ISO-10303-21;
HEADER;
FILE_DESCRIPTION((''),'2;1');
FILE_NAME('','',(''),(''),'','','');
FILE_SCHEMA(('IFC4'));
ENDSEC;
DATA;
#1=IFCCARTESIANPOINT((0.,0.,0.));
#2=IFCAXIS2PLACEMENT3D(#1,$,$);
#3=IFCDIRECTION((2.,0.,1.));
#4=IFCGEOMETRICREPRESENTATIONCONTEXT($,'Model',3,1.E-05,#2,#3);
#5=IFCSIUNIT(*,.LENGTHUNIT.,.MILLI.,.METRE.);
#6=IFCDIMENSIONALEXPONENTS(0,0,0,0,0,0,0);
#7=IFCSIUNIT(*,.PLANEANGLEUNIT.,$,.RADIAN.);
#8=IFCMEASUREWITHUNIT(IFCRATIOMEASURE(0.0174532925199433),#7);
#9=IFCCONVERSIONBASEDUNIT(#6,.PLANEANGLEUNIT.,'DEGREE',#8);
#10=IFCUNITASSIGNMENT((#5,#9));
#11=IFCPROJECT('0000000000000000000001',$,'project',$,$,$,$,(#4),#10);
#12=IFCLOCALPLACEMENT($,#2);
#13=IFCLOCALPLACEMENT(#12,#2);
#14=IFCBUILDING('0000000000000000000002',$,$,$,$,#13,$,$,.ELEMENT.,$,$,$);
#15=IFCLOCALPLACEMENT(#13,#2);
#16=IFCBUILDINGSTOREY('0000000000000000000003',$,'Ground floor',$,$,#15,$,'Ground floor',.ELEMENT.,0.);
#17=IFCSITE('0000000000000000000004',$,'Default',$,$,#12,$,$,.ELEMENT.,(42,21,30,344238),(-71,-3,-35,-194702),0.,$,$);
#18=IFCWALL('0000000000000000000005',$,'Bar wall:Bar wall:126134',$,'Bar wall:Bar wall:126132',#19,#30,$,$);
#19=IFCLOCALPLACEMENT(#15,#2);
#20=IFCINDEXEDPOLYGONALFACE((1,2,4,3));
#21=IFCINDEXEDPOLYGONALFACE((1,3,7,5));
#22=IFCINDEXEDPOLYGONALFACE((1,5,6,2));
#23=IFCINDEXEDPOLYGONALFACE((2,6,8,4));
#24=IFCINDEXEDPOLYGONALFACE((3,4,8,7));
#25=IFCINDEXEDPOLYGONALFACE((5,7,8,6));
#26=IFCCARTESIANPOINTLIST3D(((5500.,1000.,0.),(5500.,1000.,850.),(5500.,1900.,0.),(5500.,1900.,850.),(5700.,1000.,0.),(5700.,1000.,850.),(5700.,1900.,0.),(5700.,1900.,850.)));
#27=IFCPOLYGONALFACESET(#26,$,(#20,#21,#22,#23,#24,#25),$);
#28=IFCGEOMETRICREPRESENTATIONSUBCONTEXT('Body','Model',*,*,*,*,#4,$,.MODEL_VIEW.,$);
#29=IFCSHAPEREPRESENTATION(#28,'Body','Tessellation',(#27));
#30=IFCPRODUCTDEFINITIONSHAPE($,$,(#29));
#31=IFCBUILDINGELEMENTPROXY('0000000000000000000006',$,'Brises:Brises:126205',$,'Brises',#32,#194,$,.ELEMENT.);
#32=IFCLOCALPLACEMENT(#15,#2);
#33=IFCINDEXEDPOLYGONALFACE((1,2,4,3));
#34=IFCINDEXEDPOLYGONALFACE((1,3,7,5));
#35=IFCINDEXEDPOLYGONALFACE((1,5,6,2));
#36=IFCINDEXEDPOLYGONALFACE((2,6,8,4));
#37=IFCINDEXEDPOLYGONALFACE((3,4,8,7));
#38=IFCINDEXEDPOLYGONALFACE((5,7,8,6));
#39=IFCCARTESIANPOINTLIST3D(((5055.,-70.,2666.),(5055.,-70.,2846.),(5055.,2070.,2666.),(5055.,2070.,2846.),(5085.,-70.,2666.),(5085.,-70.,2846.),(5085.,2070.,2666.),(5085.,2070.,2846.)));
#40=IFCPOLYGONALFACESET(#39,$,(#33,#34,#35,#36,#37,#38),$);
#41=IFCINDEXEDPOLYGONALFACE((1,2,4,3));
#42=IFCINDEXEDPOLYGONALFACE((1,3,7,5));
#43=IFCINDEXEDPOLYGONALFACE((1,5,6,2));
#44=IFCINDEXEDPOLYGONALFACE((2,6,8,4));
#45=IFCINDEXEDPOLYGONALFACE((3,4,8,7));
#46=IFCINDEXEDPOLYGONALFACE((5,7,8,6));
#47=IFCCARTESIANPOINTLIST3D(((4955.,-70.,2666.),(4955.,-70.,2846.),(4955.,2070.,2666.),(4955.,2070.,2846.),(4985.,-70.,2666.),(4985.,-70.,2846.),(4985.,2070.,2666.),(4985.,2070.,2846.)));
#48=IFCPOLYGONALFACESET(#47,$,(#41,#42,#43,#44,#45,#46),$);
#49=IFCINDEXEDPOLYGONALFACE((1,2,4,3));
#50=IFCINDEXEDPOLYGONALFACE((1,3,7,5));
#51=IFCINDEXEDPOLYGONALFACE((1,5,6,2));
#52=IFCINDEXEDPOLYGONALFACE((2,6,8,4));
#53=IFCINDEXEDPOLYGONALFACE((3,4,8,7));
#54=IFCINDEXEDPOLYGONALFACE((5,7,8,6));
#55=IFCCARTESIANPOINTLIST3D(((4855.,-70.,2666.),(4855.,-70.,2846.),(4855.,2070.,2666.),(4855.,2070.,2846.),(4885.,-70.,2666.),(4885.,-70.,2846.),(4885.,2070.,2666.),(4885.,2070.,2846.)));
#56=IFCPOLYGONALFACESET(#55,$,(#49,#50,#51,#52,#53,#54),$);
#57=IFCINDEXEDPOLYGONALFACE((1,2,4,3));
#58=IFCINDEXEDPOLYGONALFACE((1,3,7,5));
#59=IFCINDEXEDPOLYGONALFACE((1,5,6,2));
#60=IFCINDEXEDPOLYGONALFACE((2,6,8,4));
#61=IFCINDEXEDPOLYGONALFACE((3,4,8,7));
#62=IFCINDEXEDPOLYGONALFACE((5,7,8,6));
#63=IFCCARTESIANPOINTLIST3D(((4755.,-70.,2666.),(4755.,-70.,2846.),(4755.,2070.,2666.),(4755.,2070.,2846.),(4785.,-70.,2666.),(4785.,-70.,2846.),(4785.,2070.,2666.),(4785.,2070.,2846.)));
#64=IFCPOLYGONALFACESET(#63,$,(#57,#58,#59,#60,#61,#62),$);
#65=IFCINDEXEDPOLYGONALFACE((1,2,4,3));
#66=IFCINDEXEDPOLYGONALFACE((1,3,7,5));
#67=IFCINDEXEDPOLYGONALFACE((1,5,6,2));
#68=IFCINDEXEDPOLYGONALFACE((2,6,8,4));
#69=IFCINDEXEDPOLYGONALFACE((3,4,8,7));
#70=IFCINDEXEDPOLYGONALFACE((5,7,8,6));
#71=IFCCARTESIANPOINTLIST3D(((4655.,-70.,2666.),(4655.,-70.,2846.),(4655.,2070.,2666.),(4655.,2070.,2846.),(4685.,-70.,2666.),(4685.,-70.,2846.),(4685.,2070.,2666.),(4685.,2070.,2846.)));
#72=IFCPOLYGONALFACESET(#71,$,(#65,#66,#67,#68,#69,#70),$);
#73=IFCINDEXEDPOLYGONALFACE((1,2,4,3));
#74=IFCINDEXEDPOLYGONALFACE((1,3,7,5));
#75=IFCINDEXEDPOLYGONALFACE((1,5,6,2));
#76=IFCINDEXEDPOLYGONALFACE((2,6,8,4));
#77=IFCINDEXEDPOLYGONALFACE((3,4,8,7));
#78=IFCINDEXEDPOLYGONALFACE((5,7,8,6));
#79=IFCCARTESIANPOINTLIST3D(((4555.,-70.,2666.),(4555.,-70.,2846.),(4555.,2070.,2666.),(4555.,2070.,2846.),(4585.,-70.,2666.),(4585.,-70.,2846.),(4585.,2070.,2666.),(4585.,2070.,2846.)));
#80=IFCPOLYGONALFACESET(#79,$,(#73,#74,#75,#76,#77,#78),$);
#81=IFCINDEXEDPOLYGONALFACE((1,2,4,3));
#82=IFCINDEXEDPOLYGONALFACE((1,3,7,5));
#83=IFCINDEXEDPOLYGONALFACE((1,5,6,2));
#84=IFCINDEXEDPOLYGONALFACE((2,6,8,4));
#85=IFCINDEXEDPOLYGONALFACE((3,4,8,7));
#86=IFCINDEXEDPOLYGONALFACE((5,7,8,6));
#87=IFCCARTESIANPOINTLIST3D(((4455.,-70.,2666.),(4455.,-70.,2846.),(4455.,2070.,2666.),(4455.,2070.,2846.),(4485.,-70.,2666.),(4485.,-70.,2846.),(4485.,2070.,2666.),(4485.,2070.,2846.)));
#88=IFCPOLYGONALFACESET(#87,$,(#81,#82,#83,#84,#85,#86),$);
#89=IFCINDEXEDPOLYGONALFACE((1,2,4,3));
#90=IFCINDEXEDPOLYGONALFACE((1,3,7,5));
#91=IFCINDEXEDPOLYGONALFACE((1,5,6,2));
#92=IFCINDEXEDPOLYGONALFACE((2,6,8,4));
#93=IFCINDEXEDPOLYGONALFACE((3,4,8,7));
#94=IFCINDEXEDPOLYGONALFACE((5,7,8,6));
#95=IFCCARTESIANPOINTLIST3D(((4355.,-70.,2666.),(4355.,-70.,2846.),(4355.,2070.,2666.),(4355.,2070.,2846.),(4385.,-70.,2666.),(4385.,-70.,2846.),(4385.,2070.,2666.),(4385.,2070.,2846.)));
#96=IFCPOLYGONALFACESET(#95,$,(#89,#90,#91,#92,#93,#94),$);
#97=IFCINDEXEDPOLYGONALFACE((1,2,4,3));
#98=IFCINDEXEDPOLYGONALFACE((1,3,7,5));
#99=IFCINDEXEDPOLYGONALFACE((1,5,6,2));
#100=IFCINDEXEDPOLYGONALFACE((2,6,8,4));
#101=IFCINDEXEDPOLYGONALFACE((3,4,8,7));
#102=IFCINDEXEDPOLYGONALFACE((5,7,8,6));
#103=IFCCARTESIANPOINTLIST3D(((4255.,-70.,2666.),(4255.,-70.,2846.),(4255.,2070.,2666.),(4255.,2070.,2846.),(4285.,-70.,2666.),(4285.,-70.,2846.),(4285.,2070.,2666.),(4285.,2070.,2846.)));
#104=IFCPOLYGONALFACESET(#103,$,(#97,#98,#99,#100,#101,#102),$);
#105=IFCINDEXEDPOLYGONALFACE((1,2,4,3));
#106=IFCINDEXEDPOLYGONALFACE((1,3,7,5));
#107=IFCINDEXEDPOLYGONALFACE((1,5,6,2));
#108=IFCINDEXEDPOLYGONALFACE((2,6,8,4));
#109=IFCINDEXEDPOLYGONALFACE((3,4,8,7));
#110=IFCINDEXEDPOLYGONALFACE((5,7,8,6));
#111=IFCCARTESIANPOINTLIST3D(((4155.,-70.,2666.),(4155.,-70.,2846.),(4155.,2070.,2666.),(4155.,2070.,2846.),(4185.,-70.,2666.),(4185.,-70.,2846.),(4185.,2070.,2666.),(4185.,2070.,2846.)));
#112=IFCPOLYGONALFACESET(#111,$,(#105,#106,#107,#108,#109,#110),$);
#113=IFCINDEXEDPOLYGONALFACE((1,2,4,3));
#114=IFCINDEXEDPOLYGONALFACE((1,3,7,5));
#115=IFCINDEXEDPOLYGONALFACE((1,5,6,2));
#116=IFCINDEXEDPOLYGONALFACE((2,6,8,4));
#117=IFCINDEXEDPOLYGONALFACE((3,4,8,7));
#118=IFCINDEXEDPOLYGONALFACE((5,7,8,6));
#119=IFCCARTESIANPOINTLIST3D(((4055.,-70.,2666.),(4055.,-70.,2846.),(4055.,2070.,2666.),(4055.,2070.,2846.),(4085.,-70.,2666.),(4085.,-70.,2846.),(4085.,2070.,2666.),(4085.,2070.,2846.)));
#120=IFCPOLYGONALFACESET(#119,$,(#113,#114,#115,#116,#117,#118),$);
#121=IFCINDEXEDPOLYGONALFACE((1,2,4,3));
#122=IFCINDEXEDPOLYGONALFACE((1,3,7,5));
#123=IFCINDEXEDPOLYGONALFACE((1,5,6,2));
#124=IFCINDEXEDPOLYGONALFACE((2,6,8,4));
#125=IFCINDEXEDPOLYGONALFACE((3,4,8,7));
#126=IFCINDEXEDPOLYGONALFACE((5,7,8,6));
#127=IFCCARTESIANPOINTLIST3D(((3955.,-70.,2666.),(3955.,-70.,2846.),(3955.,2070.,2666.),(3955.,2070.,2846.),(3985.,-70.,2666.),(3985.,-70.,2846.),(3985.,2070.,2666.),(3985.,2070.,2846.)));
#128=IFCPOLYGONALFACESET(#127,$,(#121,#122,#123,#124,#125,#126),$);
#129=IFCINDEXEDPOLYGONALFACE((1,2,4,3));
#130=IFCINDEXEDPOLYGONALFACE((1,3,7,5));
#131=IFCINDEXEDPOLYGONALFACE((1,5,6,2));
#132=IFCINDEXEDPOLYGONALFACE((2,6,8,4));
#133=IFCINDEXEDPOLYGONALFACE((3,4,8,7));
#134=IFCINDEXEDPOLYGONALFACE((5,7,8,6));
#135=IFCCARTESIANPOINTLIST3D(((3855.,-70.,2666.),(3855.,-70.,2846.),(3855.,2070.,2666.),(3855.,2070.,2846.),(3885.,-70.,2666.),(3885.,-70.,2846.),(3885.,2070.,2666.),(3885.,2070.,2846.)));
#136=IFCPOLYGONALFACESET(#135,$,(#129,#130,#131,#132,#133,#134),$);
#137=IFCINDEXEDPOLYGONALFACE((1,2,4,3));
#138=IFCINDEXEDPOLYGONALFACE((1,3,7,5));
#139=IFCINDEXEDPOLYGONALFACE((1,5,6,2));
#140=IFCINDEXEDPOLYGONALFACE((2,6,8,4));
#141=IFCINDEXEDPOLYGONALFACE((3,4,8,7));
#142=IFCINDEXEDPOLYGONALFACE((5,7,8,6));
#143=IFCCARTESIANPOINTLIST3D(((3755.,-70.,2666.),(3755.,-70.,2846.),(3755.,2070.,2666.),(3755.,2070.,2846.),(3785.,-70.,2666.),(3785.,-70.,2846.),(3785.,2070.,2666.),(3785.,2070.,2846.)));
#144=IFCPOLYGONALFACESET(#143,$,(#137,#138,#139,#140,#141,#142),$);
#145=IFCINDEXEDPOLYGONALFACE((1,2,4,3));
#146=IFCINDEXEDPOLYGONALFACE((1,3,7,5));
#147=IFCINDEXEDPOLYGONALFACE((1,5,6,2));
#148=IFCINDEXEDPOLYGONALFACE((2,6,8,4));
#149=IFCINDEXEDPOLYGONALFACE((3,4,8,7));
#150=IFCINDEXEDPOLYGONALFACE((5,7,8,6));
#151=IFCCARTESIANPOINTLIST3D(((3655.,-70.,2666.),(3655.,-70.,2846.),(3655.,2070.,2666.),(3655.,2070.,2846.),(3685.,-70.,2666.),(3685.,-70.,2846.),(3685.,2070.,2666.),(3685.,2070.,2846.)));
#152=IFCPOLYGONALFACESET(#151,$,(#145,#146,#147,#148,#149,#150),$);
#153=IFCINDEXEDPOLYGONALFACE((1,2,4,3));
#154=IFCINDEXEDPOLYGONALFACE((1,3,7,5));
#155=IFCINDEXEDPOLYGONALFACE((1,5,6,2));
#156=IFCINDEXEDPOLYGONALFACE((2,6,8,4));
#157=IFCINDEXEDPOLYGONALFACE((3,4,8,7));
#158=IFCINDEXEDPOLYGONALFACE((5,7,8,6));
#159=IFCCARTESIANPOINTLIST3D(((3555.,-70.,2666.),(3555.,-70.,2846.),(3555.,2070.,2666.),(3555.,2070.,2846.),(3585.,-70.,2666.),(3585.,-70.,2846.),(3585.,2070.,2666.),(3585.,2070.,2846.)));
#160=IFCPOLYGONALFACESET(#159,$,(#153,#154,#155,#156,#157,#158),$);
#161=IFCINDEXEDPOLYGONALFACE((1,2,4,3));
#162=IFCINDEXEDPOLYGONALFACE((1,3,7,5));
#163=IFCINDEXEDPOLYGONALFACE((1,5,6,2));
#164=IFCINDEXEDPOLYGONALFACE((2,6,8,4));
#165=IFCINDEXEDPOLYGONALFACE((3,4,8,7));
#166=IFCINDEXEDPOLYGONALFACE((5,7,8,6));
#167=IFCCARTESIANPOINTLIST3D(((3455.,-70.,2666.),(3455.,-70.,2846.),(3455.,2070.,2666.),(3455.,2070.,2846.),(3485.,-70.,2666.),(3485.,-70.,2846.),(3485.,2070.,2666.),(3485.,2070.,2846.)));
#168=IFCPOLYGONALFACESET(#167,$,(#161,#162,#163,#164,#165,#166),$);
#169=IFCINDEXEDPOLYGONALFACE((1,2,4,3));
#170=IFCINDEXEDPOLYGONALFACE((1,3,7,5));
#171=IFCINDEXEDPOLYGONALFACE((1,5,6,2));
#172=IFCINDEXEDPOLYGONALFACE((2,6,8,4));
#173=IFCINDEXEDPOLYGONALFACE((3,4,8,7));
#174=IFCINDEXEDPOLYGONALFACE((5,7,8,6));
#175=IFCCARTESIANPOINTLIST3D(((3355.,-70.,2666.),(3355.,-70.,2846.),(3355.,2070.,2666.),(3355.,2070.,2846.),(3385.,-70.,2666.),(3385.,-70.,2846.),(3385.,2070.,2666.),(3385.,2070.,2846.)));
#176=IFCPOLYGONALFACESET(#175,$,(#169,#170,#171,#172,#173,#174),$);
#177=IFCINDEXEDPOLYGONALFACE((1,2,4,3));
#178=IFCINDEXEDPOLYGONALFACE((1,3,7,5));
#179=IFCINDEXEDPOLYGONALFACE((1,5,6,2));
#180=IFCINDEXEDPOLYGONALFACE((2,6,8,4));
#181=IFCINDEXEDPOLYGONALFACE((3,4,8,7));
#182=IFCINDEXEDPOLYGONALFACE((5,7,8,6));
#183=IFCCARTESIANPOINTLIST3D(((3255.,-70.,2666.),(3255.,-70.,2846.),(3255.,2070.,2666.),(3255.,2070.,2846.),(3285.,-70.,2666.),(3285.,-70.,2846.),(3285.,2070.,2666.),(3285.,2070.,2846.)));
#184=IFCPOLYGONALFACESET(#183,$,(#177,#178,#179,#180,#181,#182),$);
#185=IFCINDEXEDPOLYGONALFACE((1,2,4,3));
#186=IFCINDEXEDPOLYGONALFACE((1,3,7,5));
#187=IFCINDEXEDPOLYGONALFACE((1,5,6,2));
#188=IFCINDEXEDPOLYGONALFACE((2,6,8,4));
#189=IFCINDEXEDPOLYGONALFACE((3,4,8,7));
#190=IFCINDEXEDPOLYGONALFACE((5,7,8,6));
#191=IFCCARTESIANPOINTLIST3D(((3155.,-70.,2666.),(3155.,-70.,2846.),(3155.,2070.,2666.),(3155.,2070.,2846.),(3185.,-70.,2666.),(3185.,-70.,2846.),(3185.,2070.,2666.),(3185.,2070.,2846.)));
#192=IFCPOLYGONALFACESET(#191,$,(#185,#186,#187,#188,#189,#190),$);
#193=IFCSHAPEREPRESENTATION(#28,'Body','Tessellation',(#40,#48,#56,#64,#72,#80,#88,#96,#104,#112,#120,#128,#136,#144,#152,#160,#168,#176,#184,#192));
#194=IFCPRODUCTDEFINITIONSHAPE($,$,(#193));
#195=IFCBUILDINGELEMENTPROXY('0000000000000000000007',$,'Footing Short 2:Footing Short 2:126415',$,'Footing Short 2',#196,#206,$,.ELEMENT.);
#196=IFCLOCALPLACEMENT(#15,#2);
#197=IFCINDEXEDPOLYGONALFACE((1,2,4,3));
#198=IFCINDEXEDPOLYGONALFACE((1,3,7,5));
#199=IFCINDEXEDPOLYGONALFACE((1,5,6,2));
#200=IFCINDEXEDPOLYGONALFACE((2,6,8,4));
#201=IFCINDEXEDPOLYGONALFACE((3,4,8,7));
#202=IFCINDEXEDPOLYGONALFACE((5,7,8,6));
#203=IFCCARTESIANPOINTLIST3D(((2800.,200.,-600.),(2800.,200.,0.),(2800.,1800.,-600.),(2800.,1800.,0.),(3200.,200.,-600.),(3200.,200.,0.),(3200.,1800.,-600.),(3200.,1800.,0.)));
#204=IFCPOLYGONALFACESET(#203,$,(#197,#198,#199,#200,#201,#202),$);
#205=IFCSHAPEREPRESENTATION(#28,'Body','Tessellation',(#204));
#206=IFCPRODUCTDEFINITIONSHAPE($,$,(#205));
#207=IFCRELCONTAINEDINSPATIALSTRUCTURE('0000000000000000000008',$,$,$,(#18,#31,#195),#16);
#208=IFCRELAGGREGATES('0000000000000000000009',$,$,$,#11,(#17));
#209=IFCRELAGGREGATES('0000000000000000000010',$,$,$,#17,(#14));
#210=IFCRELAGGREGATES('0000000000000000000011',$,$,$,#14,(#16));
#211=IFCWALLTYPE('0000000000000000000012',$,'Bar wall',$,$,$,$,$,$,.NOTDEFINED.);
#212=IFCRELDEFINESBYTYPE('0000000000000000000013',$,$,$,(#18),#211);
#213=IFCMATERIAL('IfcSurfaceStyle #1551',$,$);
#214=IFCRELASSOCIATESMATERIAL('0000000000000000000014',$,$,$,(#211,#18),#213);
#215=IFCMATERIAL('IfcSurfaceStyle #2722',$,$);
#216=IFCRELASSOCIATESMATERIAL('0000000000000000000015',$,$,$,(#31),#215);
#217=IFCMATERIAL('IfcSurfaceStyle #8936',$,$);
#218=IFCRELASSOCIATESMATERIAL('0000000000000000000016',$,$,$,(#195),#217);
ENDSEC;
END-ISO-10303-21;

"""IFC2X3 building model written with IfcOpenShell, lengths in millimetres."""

from ifc_helpers import new_model, entity, si_unit, converted_unit, direction, frame, frame_2d, origin, origin_2d_with_axis, place, context, subcontext, project, spatial, rectangle, extrude, source, transform, mapped, material, type_object, element, save


model = new_model("IFC2X3")

# Units and contexts
model_context = context("Model", 3, precision=1e-05, world=origin(), true_north=direction((2.0, 0.0, 1.0)))
body_context = subcontext(model_context, "Body", "Model", "MODEL_VIEW")
ifc_project = project(units=[si_unit("LENGTHUNIT", "METRE", prefix="MILLI"), converted_unit("PLANEANGLEUNIT", "DEGREE", entity("IfcRatioMeasure", 0.0174532925199433), si_unit("PLANEANGLEUNIT", "RADIAN"), dimensions=[0, 0, 0, 0, 0, 0, 0])], contexts=[model_context])

# Site, building, storey
site_placement = place(None, origin())
site = spatial("IfcSite", under=ifc_project, at=site_placement, Name="Default", CompositionType="ELEMENT", RefLatitude=(42, 21, 30, 344238), RefLongitude=(-71, -3, -35, -194702), RefElevation=0.0)
building_placement = place(site_placement, origin())
building = spatial("IfcBuilding", under=site, at=building_placement, CompositionType="ELEMENT")
storey_placement = place(building_placement, origin())
storey = spatial("IfcBuildingStorey", under=building, at=storey_placement, Name="Ground floor", LongName="Ground floor", CompositionType="ELEMENT", Elevation=0.0)

# Wall
ifc_material_1 = material(Name="IfcSurfaceStyle #1551")
wall_type = type_object("IfcWallType", Name="Bar wall", PredefinedType="NOTDEFINED", material=ifc_material_1)
wall_placement = place(building_placement, frame((5500.0, 1000.0, 0.0), z_axis=(0.0, 0.0, 1.0), x_axis=(0.0, 1.0, 0.0)))
element("IfcWall", 1, at=wall_placement, inside=storey, type_object=wall_type, material=ifc_material_1, Name="Bar wall:Bar wall:126134", ObjectType="Bar wall:Bar wall:126132", context=body_context, shape_type="SweptSolid", body=[
    extrude(rectangle(XDim=200.0, YDim=900.0, at=origin_2d_with_axis()), frame((450.0, -100.0, 0.0), z_axis=(0.0, 0.0, 1.0), x_axis=(0.0, -1.0, 0.0)), (0.0, 0.0, 1.0), 850.0),
])

# Building element proxies
ifc_material_2 = material(Name="IfcSurfaceStyle #2722")
shared_shape_1 = source(origin(), body_context, "Body", "SweptSolid", [
    extrude(rectangle(XDim=2140.0, YDim=30.0, at=frame_2d((0.0, 0.0), x_axis=(1.0, 0.0))), frame((1915.0, 1070.0, 0.0), z_axis=(0.0, 0.0, 1.0), x_axis=(0.0, -1.0, 0.0)), (0.0, 0.0, 1.0), 180.0),
    extrude(rectangle(XDim=2140.0, YDim=30.0, at=frame_2d((0.0, 0.0), x_axis=(1.0, 0.0))), frame((1815.0, 1070.0, 0.0), z_axis=(0.0, 0.0, 1.0), x_axis=(0.0, -1.0, 0.0)), (0.0, 0.0, 1.0), 180.0),
    extrude(rectangle(XDim=2140.0, YDim=30.0, at=frame_2d((0.0, 0.0), x_axis=(1.0, 0.0))), frame((1715.0, 1070.0, 0.0), z_axis=(0.0, 0.0, 1.0), x_axis=(0.0, -1.0, 0.0)), (0.0, 0.0, 1.0), 180.0),
    extrude(rectangle(XDim=2140.0, YDim=30.0, at=origin_2d_with_axis()), frame((1615.0, 1070.0, 0.0), z_axis=(0.0, 0.0, 1.0), x_axis=(0.0, -1.0, 0.0)), (0.0, 0.0, 1.0), 180.0),
    extrude(rectangle(XDim=2140.0, YDim=30.0, at=origin_2d_with_axis()), frame((1515.0, 1070.0, 0.0), z_axis=(0.0, 0.0, 1.0), x_axis=(0.0, -1.0, 0.0)), (0.0, 0.0, 1.0), 180.0),
    extrude(rectangle(XDim=2140.0, YDim=30.0, at=origin_2d_with_axis()), frame((1415.0, 1070.0, 0.0), z_axis=(0.0, 0.0, 1.0), x_axis=(0.0, -1.0, 0.0)), (0.0, 0.0, 1.0), 180.0),
    extrude(rectangle(XDim=2140.0, YDim=30.0, at=origin_2d_with_axis()), frame((1315.0, 1070.0, 0.0), z_axis=(0.0, 0.0, 1.0), x_axis=(0.0, -1.0, 0.0)), (0.0, 0.0, 1.0), 180.0),
    extrude(rectangle(XDim=2140.0, YDim=30.0, at=origin_2d_with_axis()), frame((1215.0, 1070.0, 0.0), z_axis=(0.0, 0.0, 1.0), x_axis=(0.0, -1.0, 0.0)), (0.0, 0.0, 1.0), 180.0),
    extrude(rectangle(XDim=2140.0, YDim=30.0, at=origin_2d_with_axis()), frame((1115.0, 1070.0, 0.0), z_axis=(0.0, 0.0, 1.0), x_axis=(0.0, -1.0, 0.0)), (0.0, 0.0, 1.0), 180.0),
    extrude(rectangle(XDim=2140.0, YDim=30.0, at=origin_2d_with_axis()), frame((1015.0, 1070.0, 0.0), z_axis=(0.0, 0.0, 1.0), x_axis=(0.0, -1.0, 0.0)), (0.0, 0.0, 1.0), 180.0),
    extrude(rectangle(XDim=2140.0, YDim=30.0, at=origin_2d_with_axis()), frame((915.0, 1070.0, 0.0), z_axis=(0.0, 0.0, 1.0), x_axis=(0.0, -1.0, 0.0)), (0.0, 0.0, 1.0), 180.0),
    extrude(rectangle(XDim=2140.0, YDim=30.0, at=origin_2d_with_axis()), frame((815.0, 1070.0, 0.0), z_axis=(0.0, 0.0, 1.0), x_axis=(0.0, -1.0, 0.0)), (0.0, 0.0, 1.0), 180.0),
    extrude(rectangle(XDim=2140.0, YDim=30.0, at=origin_2d_with_axis()), frame((715.0, 1070.0, 0.0), z_axis=(0.0, 0.0, 1.0), x_axis=(0.0, -1.0, 0.0)), (0.0, 0.0, 1.0), 180.0),
    extrude(rectangle(XDim=2140.0, YDim=30.0, at=origin_2d_with_axis()), frame((615.0, 1070.0, 0.0), z_axis=(0.0, 0.0, 1.0), x_axis=(0.0, -1.0, 0.0)), (0.0, 0.0, 1.0), 180.0),
    extrude(rectangle(XDim=2140.0, YDim=30.0, at=origin_2d_with_axis()), frame((515.0, 1070.0, 0.0), z_axis=(0.0, 0.0, 1.0), x_axis=(0.0, -1.0, 0.0)), (0.0, 0.0, 1.0), 180.0),
    extrude(rectangle(XDim=2140.0, YDim=30.0, at=origin_2d_with_axis()), frame((415.0, 1070.0, 0.0), z_axis=(0.0, 0.0, 1.0), x_axis=(0.0, -1.0, 0.0)), (0.0, 0.0, 1.0), 180.0),
    extrude(rectangle(XDim=2140.0, YDim=30.0, at=origin_2d_with_axis()), frame((315.0, 1070.0, 0.0), z_axis=(0.0, 0.0, 1.0), x_axis=(0.0, -1.0, 0.0)), (0.0, 0.0, 1.0), 180.0),
    extrude(rectangle(XDim=2140.0, YDim=30.0, at=origin_2d_with_axis()), frame((215.0, 1070.0, 0.0), z_axis=(0.0, 0.0, 1.0), x_axis=(0.0, -1.0, 0.0)), (0.0, 0.0, 1.0), 180.0),
    extrude(rectangle(XDim=2140.0, YDim=30.0, at=origin_2d_with_axis()), frame((115.0, 1070.0, 0.0), z_axis=(0.0, 0.0, 1.0), x_axis=(0.0, -1.0, 0.0)), (0.0, 0.0, 1.0), 180.0),
    extrude(rectangle(XDim=2140.0, YDim=30.0, at=origin_2d_with_axis()), frame((15.0, 1070.0, 0.0), z_axis=(0.0, 0.0, 1.0), x_axis=(0.0, -1.0, 0.0)), (0.0, 0.0, 1.0), 180.0),
])
proxy_1_placement = place(building_placement, frame((3155.0, -70.0, 2666.0)))
element("IfcBuildingElementProxy", 2, at=proxy_1_placement, inside=storey, material=ifc_material_2, Name="Brises:Brises:126205", ObjectType="Brises", CompositionType="ELEMENT", context=body_context, shape_type="MappedRepresentation", body=[
    mapped(shared_shape_1, transform((0.0, 0.0, 0.0), scale=1.0)),
])
ifc_material_3 = material(Name="IfcSurfaceStyle #8936")
shared_shape_2 = source(origin(), body_context, "Body", "SweptSolid", [
    extrude(rectangle(XDim=1600.0, YDim=400.0, at=origin_2d_with_axis()), frame((200.0, 800.0, 0.0), z_axis=(0.0, 0.0, 1.0), x_axis=(0.0, -1.0, 0.0)), (0.0, 0.0, 1.0), 600.0),
])
proxy_2_placement = place(building_placement, frame((2800.0, 200.0, -600.0)))
element("IfcBuildingElementProxy", 3, at=proxy_2_placement, inside=storey, material=ifc_material_3, Name="Footing Short 2:Footing Short 2:126415", ObjectType="Footing Short 2", CompositionType="ELEMENT", context=body_context, shape_type="MappedRepresentation", body=[
    mapped(shared_shape_2, transform((0.0, 0.0, 0.0), scale=1.0)),
])

save(model, "model.ifc")
